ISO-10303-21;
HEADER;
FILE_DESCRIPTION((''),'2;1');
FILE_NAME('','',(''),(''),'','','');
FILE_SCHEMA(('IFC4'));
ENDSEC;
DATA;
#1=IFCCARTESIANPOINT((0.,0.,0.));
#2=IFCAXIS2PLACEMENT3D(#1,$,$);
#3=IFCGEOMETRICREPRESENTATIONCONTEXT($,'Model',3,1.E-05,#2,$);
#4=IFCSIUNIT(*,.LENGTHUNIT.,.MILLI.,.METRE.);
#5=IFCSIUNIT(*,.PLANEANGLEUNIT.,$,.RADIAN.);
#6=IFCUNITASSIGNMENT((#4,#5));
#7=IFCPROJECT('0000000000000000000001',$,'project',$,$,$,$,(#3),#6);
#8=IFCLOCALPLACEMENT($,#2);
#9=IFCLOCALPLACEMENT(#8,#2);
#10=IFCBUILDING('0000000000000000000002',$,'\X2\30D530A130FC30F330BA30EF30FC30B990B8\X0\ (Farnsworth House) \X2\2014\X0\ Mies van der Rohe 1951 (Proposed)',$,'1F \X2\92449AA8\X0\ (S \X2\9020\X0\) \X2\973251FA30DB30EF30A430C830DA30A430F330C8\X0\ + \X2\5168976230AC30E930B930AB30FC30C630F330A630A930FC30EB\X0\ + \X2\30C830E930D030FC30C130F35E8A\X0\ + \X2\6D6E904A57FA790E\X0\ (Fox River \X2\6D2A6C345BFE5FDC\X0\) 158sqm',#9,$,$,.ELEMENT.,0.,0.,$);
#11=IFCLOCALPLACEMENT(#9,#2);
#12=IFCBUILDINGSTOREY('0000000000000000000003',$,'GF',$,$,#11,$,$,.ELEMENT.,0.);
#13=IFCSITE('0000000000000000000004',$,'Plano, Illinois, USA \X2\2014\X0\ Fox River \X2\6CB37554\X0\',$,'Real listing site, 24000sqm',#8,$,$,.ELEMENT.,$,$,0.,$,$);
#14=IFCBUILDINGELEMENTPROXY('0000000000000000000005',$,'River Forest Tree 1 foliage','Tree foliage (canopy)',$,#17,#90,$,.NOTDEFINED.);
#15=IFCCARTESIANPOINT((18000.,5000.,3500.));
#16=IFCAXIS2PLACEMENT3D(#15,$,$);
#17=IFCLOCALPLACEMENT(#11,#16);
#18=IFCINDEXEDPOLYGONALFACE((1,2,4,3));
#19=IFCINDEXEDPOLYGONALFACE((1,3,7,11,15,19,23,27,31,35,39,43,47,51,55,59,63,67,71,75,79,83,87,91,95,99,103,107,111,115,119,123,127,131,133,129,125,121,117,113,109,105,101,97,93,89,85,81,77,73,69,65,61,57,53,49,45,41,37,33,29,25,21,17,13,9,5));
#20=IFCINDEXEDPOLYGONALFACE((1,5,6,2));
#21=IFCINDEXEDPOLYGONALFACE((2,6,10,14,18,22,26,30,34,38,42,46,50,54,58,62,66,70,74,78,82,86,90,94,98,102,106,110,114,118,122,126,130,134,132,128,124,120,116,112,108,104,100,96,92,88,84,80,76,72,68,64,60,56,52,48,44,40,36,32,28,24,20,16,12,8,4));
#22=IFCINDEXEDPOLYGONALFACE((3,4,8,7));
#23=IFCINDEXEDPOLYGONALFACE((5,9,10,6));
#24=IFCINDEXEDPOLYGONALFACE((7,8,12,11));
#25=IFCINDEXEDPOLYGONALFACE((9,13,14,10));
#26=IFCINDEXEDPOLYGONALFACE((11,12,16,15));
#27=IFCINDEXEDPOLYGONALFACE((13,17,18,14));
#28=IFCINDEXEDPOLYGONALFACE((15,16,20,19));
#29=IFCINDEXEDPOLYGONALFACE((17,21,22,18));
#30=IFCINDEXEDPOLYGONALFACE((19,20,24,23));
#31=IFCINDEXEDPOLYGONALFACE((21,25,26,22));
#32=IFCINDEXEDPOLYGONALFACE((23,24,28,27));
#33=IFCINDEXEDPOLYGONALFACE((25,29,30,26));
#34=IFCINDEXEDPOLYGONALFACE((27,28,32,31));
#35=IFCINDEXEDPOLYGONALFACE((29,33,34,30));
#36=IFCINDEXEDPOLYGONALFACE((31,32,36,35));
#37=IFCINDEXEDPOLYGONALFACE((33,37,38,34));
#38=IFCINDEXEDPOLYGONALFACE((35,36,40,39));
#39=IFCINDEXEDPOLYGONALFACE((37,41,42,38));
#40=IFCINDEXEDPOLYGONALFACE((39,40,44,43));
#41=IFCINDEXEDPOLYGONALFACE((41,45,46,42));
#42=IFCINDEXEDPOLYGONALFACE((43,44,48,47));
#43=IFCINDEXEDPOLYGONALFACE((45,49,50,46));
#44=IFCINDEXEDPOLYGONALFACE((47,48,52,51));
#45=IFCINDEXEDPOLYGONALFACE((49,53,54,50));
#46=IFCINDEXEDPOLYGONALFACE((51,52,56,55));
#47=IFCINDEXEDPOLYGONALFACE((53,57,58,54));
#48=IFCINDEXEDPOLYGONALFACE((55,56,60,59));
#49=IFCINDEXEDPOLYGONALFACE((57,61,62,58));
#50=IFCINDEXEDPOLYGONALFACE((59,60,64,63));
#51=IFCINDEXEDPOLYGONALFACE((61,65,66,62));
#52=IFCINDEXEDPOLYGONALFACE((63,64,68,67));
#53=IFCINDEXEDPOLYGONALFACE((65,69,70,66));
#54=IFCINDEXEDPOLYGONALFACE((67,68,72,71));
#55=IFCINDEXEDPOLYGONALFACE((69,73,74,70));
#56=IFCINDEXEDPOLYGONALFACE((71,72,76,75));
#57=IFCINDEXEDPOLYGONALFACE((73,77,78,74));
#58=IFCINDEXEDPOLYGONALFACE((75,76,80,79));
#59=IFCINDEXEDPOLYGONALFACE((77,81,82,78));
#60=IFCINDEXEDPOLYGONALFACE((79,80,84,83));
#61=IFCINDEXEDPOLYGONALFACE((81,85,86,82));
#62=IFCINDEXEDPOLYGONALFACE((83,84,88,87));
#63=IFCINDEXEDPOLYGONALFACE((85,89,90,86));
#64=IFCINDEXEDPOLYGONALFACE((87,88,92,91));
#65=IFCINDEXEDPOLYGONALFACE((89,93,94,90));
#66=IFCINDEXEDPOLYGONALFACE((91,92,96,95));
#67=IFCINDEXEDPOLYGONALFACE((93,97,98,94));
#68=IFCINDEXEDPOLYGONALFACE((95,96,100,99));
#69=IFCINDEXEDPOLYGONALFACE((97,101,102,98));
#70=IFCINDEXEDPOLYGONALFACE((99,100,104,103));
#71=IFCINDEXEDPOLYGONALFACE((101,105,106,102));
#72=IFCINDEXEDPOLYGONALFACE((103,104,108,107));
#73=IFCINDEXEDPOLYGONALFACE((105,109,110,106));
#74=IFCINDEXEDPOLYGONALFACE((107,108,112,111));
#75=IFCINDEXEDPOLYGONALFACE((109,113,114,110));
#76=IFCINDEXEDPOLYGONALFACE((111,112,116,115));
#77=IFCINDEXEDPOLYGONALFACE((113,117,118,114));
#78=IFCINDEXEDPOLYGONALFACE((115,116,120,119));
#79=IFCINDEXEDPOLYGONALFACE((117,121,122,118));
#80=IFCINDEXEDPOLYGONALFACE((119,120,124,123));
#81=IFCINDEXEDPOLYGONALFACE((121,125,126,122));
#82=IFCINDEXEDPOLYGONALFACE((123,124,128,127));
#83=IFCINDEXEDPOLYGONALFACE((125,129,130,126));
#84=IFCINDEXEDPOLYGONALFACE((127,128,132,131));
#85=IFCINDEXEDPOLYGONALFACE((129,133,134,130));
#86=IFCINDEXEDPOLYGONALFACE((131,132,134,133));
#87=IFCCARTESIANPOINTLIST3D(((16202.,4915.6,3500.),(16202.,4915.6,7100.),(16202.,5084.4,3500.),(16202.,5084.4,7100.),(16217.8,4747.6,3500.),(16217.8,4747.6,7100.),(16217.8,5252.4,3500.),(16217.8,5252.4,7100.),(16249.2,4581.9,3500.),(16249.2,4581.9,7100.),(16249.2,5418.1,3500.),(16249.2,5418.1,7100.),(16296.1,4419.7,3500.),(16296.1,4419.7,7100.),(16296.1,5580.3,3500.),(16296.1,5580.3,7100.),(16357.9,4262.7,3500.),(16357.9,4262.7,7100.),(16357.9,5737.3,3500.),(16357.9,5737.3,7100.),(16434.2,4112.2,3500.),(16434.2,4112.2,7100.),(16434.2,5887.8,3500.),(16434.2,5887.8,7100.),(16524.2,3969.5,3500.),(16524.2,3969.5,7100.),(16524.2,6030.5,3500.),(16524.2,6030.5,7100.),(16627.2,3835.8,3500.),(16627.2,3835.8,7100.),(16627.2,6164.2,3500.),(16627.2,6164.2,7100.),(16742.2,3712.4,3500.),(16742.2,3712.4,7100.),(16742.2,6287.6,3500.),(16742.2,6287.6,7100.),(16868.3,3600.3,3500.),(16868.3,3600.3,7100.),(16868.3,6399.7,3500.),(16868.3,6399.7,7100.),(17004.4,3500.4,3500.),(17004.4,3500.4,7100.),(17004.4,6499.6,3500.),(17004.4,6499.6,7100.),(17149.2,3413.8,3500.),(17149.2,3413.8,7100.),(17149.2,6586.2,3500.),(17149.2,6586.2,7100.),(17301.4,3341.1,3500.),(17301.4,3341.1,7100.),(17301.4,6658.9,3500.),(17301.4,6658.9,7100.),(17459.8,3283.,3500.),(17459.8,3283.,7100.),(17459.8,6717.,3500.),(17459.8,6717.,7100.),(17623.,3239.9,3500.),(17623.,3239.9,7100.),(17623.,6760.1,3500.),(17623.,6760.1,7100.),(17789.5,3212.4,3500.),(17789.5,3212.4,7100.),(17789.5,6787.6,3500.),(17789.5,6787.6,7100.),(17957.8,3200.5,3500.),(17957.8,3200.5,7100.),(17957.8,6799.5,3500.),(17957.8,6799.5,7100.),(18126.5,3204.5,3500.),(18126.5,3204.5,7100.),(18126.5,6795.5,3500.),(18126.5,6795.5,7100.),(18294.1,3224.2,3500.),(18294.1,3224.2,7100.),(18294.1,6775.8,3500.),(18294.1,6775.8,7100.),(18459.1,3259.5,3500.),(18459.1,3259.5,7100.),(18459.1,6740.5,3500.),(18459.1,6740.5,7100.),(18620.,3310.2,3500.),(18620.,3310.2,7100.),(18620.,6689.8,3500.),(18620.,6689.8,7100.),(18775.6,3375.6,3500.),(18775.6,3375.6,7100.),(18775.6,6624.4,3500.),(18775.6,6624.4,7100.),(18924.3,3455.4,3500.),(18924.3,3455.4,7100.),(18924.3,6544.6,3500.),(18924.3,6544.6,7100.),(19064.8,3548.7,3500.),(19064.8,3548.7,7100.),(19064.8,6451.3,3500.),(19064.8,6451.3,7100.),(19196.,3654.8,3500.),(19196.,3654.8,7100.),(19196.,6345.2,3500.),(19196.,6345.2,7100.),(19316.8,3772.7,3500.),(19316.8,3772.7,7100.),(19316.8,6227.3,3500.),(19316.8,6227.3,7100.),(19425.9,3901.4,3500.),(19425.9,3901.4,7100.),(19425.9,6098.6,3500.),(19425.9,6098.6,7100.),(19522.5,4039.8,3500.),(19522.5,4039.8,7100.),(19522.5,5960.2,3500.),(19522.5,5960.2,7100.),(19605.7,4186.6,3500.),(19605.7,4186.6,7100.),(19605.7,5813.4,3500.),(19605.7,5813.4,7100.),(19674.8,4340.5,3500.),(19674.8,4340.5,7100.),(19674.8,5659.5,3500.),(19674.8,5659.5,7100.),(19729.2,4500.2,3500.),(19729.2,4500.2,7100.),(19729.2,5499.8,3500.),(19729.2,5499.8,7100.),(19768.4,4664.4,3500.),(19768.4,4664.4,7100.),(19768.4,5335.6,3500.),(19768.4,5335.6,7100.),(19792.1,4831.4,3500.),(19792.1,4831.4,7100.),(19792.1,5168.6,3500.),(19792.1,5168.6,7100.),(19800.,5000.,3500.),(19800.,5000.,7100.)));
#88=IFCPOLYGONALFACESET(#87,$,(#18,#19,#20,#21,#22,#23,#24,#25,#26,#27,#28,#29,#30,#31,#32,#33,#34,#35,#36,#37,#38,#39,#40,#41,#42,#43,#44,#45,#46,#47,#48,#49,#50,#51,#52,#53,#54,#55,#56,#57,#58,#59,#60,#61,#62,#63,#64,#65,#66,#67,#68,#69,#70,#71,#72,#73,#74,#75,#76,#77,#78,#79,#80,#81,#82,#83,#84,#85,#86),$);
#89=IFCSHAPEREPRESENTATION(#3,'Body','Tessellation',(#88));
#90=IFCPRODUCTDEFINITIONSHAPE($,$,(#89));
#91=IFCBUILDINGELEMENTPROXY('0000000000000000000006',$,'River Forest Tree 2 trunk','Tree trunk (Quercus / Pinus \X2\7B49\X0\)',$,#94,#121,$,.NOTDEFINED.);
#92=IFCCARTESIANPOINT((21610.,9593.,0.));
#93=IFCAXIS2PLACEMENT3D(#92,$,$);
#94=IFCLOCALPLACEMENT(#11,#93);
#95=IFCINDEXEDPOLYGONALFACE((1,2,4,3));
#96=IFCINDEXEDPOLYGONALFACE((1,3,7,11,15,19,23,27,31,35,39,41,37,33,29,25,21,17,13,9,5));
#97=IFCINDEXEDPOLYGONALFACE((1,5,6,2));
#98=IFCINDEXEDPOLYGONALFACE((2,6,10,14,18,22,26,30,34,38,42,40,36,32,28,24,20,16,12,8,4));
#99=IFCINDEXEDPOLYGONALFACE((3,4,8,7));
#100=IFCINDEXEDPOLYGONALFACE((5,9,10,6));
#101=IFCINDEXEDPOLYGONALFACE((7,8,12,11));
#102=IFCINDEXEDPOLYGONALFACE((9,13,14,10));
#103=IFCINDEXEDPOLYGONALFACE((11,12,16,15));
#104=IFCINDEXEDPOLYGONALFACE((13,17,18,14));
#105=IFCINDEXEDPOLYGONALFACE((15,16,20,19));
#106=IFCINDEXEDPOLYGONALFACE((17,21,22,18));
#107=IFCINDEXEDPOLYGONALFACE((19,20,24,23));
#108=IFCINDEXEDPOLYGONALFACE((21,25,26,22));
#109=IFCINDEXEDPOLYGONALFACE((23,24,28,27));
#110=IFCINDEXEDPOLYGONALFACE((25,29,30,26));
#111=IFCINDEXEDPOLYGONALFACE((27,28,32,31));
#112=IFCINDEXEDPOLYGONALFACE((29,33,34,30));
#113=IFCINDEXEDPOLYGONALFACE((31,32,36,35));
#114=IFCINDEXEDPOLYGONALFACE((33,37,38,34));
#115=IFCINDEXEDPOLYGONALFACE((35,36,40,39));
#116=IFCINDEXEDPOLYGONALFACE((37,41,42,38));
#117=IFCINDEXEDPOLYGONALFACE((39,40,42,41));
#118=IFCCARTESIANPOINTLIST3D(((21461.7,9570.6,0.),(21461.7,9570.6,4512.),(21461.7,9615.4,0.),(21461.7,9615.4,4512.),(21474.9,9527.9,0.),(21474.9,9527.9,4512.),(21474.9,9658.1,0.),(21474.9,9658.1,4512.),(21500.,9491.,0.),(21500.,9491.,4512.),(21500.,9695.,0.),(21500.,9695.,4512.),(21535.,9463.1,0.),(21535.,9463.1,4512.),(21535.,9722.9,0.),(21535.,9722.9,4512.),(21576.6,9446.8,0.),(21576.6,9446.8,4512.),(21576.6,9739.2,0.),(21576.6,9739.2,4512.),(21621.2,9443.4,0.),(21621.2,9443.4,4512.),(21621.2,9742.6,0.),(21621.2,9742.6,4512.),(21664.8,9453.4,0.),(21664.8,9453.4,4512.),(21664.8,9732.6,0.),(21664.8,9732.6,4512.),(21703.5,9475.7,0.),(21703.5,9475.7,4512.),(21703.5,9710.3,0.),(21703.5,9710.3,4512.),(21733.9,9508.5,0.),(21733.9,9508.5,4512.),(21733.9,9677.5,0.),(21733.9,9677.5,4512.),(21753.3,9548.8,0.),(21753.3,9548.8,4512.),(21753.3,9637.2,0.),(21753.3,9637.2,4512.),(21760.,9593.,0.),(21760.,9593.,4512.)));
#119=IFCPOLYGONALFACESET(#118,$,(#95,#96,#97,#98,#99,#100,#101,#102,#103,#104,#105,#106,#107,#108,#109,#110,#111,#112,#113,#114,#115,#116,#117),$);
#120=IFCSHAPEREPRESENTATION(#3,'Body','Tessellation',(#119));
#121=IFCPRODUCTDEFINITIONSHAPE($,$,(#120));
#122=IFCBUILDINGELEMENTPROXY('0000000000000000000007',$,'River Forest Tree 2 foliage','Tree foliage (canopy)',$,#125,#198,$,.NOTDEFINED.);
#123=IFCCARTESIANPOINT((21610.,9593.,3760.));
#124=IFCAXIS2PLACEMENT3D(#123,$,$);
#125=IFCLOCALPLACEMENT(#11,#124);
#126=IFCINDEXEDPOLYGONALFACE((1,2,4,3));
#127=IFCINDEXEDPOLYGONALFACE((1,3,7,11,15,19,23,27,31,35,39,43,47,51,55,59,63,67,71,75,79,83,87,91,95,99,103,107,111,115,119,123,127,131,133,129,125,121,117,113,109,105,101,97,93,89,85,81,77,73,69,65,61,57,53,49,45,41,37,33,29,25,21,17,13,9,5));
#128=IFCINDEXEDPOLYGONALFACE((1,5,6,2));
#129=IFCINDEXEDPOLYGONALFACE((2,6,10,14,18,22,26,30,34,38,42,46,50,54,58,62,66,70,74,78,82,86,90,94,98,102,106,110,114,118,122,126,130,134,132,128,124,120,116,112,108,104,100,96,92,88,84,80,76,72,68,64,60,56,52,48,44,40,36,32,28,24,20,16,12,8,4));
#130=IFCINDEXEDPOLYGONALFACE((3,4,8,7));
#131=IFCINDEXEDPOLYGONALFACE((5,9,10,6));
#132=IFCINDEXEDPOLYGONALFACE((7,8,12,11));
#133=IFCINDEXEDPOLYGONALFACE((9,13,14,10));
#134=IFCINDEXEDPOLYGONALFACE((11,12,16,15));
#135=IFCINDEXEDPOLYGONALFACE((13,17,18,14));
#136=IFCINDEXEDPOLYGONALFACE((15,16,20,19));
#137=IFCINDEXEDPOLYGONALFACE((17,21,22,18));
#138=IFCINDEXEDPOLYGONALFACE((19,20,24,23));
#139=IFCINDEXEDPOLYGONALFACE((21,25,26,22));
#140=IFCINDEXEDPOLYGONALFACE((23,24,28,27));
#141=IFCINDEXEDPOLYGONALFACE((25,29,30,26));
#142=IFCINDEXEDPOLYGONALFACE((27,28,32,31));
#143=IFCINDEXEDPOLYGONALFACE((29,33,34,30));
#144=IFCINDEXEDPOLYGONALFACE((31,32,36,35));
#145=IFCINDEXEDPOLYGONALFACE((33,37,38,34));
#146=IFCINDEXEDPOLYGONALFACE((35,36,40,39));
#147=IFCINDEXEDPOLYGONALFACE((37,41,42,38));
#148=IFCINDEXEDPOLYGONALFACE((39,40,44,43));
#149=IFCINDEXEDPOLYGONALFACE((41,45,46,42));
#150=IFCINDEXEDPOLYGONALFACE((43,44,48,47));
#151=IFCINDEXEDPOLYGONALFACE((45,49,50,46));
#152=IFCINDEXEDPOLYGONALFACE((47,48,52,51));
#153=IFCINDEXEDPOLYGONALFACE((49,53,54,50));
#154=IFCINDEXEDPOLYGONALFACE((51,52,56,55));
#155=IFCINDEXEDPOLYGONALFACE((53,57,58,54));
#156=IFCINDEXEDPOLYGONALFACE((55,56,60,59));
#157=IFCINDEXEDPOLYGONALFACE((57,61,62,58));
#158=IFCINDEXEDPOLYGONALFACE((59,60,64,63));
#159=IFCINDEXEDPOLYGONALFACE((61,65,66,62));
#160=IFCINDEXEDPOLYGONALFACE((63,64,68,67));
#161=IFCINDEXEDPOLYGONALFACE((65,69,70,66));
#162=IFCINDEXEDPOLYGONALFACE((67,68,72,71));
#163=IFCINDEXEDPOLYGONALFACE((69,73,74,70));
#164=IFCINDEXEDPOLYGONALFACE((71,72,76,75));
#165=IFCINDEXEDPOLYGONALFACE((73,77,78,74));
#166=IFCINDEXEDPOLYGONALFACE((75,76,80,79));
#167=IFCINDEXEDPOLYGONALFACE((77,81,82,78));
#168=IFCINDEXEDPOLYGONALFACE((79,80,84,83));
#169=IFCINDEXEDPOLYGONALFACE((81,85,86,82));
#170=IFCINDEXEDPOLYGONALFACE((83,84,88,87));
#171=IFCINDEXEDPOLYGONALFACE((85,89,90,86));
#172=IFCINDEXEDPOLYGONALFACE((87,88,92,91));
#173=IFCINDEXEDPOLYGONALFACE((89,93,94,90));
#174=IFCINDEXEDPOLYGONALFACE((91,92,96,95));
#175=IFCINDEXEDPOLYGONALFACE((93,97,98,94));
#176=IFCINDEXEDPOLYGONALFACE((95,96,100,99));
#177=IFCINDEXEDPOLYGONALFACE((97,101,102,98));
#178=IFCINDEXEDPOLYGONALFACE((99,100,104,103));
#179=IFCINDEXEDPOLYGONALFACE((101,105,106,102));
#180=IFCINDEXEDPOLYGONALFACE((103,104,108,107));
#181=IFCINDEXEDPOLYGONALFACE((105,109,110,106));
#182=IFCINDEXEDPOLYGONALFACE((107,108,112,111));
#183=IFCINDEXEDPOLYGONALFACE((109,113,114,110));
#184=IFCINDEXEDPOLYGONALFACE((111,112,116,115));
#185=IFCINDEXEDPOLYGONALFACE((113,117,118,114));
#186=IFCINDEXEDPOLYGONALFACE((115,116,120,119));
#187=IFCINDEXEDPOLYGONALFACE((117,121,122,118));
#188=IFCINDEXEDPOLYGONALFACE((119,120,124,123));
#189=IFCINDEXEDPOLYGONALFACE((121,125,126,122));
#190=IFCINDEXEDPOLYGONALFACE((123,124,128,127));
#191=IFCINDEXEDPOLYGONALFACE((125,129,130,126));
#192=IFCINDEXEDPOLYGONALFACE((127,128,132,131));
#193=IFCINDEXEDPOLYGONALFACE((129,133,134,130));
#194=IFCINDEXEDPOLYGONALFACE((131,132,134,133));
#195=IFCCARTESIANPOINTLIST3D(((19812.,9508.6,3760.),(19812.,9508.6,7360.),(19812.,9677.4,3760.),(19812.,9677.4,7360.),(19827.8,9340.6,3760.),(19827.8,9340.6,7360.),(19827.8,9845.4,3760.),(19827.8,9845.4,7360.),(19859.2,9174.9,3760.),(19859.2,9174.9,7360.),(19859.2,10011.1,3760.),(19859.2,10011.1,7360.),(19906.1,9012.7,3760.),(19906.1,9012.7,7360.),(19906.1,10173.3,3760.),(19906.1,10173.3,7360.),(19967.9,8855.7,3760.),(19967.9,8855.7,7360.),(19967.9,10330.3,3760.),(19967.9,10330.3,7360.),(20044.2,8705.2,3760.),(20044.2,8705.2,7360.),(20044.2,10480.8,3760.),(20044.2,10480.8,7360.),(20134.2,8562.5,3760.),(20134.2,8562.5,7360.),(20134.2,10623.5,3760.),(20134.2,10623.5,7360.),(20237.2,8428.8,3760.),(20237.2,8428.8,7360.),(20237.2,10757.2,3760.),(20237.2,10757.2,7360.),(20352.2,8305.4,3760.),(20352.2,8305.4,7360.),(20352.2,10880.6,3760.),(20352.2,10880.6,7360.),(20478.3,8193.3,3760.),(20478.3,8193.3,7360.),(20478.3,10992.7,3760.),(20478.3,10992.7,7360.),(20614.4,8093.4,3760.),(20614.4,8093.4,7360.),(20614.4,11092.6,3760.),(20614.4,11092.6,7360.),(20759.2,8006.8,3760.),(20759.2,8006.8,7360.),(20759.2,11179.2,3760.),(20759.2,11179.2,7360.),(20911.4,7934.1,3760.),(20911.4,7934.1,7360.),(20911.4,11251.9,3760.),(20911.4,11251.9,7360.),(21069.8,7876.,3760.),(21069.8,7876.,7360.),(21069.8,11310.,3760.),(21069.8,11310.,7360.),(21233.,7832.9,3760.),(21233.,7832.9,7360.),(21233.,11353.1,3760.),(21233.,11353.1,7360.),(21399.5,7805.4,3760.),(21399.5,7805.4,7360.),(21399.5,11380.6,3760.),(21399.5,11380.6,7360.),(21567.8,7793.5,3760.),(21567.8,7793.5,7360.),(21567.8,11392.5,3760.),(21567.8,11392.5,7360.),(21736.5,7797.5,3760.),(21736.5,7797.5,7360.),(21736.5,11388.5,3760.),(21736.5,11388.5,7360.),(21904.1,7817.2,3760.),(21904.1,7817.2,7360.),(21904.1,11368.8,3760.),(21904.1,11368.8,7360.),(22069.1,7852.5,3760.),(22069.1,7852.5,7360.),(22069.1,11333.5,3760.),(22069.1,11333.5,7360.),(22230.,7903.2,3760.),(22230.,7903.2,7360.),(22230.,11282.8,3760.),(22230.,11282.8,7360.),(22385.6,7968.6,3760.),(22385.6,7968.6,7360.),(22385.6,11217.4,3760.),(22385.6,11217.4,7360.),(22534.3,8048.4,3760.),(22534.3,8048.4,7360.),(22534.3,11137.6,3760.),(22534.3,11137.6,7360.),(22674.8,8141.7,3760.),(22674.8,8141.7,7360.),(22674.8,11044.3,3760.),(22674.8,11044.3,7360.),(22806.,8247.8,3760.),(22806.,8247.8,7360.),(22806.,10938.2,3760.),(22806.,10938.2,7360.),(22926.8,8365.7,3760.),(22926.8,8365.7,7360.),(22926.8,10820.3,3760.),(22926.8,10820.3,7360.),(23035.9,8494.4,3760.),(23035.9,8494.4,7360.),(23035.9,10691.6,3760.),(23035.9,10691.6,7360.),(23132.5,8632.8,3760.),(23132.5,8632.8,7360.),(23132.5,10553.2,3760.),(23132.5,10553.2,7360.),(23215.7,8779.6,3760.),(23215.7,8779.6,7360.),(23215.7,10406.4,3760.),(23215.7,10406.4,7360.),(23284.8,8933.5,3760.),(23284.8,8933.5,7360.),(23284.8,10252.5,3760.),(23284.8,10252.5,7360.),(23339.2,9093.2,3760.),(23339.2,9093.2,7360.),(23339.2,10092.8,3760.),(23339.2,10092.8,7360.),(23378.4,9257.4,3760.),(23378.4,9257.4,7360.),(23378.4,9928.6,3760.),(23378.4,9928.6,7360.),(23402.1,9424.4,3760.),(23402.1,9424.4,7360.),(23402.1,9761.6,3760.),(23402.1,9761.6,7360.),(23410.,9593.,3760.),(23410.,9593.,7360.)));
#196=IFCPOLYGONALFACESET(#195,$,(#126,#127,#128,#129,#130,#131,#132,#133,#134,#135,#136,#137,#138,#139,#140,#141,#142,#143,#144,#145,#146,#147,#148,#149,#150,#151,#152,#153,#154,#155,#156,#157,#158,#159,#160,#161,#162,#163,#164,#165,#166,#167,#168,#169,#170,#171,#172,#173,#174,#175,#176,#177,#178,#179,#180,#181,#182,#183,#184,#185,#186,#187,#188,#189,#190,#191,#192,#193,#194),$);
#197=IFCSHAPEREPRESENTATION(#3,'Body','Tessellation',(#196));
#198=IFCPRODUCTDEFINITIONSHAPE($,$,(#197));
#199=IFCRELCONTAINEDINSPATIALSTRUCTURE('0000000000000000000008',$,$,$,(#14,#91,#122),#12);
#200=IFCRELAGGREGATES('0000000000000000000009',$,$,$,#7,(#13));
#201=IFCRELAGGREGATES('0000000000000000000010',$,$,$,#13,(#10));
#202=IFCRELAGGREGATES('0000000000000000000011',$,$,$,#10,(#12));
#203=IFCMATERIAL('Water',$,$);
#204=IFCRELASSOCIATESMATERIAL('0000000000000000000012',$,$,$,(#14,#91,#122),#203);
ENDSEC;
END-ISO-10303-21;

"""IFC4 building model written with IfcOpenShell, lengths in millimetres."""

from ifc_helpers import new_model, si_unit, frame, origin, origin_2d, place, context, project, spatial, circle, extrude, material, element, save


model = new_model("IFC4")

# Units and contexts
model_context = context("Model", 3, precision=1e-05, world=origin())
ifc_project = project(units=[si_unit("LENGTHUNIT", "METRE", prefix="MILLI"), si_unit("PLANEANGLEUNIT", "RADIAN")], contexts=[model_context])

# Site, building, storey
site_placement = place(None, origin())
site = spatial("IfcSite", under=ifc_project, at=site_placement, Name="Plano, Illinois, USA — Fox River 河畔", ObjectType="Real listing site, 24000sqm", CompositionType="ELEMENT", RefElevation=0.0)
building_placement = place(site_placement, origin())
building = spatial("IfcBuilding", under=site, at=building_placement, Name="ファーンズワース邸 (Farnsworth House) — Mies van der Rohe 1951 (Proposed)", ObjectType="1F 鉄骨 (S 造) 露出ホワイトペイント + 全面ガラスカーテンウォール + トラバーチン床 + 浮遊基礎 (Fox River 洪水対応) 158sqm", CompositionType="ELEMENT", ElevationOfRefHeight=0.0, ElevationOfTerrain=0.0)
storey_placement = place(building_placement, origin())
storey = spatial("IfcBuildingStorey", under=building, at=storey_placement, Name="GF", CompositionType="ELEMENT", Elevation=0.0)

# Building element proxies
ifc_material_1 = material(Name="Water")
proxy_1_placement = place(storey_placement, frame((18000.0, 5000.0, 3500.0)))
element("IfcBuildingElementProxy", 1, at=proxy_1_placement, inside=storey, material=ifc_material_1, Name="River Forest Tree 1 foliage", Description="Tree foliage (canopy)", PredefinedType="NOTDEFINED", context=model_context, shape_type="SweptSolid", body=[
    extrude(circle(Radius=1800.0, at=origin_2d()), frame((18000.0, 5000.0, 3500.0)), (0.0, 0.0, 1.0), 3600.0),
])
proxy_2_placement = place(storey_placement, frame((21610.0, 9593.0, 0.0)))
element("IfcBuildingElementProxy", 2, at=proxy_2_placement, inside=storey, material=ifc_material_1, Name="River Forest Tree 2 trunk", Description="Tree trunk (Quercus / Pinus 等)", PredefinedType="NOTDEFINED", context=model_context, shape_type="SweptSolid", body=[
    extrude(circle(Radius=150.0, at=origin_2d()), frame((21610.0, 9593.0, 0.0)), (0.0, 0.0, 1.0), 4512.0),
])
proxy_3_placement = place(storey_placement, frame((21610.0, 9593.0, 3760.0)))
element("IfcBuildingElementProxy", 3, at=proxy_3_placement, inside=storey, material=ifc_material_1, Name="River Forest Tree 2 foliage", Description="Tree foliage (canopy)", PredefinedType="NOTDEFINED", context=model_context, shape_type="SweptSolid", body=[
    extrude(circle(Radius=1800.0, at=origin_2d()), frame((21610.0, 9593.0, 3760.0)), (0.0, 0.0, 1.0), 3600.0),
])

save(model, "model.ifc")
